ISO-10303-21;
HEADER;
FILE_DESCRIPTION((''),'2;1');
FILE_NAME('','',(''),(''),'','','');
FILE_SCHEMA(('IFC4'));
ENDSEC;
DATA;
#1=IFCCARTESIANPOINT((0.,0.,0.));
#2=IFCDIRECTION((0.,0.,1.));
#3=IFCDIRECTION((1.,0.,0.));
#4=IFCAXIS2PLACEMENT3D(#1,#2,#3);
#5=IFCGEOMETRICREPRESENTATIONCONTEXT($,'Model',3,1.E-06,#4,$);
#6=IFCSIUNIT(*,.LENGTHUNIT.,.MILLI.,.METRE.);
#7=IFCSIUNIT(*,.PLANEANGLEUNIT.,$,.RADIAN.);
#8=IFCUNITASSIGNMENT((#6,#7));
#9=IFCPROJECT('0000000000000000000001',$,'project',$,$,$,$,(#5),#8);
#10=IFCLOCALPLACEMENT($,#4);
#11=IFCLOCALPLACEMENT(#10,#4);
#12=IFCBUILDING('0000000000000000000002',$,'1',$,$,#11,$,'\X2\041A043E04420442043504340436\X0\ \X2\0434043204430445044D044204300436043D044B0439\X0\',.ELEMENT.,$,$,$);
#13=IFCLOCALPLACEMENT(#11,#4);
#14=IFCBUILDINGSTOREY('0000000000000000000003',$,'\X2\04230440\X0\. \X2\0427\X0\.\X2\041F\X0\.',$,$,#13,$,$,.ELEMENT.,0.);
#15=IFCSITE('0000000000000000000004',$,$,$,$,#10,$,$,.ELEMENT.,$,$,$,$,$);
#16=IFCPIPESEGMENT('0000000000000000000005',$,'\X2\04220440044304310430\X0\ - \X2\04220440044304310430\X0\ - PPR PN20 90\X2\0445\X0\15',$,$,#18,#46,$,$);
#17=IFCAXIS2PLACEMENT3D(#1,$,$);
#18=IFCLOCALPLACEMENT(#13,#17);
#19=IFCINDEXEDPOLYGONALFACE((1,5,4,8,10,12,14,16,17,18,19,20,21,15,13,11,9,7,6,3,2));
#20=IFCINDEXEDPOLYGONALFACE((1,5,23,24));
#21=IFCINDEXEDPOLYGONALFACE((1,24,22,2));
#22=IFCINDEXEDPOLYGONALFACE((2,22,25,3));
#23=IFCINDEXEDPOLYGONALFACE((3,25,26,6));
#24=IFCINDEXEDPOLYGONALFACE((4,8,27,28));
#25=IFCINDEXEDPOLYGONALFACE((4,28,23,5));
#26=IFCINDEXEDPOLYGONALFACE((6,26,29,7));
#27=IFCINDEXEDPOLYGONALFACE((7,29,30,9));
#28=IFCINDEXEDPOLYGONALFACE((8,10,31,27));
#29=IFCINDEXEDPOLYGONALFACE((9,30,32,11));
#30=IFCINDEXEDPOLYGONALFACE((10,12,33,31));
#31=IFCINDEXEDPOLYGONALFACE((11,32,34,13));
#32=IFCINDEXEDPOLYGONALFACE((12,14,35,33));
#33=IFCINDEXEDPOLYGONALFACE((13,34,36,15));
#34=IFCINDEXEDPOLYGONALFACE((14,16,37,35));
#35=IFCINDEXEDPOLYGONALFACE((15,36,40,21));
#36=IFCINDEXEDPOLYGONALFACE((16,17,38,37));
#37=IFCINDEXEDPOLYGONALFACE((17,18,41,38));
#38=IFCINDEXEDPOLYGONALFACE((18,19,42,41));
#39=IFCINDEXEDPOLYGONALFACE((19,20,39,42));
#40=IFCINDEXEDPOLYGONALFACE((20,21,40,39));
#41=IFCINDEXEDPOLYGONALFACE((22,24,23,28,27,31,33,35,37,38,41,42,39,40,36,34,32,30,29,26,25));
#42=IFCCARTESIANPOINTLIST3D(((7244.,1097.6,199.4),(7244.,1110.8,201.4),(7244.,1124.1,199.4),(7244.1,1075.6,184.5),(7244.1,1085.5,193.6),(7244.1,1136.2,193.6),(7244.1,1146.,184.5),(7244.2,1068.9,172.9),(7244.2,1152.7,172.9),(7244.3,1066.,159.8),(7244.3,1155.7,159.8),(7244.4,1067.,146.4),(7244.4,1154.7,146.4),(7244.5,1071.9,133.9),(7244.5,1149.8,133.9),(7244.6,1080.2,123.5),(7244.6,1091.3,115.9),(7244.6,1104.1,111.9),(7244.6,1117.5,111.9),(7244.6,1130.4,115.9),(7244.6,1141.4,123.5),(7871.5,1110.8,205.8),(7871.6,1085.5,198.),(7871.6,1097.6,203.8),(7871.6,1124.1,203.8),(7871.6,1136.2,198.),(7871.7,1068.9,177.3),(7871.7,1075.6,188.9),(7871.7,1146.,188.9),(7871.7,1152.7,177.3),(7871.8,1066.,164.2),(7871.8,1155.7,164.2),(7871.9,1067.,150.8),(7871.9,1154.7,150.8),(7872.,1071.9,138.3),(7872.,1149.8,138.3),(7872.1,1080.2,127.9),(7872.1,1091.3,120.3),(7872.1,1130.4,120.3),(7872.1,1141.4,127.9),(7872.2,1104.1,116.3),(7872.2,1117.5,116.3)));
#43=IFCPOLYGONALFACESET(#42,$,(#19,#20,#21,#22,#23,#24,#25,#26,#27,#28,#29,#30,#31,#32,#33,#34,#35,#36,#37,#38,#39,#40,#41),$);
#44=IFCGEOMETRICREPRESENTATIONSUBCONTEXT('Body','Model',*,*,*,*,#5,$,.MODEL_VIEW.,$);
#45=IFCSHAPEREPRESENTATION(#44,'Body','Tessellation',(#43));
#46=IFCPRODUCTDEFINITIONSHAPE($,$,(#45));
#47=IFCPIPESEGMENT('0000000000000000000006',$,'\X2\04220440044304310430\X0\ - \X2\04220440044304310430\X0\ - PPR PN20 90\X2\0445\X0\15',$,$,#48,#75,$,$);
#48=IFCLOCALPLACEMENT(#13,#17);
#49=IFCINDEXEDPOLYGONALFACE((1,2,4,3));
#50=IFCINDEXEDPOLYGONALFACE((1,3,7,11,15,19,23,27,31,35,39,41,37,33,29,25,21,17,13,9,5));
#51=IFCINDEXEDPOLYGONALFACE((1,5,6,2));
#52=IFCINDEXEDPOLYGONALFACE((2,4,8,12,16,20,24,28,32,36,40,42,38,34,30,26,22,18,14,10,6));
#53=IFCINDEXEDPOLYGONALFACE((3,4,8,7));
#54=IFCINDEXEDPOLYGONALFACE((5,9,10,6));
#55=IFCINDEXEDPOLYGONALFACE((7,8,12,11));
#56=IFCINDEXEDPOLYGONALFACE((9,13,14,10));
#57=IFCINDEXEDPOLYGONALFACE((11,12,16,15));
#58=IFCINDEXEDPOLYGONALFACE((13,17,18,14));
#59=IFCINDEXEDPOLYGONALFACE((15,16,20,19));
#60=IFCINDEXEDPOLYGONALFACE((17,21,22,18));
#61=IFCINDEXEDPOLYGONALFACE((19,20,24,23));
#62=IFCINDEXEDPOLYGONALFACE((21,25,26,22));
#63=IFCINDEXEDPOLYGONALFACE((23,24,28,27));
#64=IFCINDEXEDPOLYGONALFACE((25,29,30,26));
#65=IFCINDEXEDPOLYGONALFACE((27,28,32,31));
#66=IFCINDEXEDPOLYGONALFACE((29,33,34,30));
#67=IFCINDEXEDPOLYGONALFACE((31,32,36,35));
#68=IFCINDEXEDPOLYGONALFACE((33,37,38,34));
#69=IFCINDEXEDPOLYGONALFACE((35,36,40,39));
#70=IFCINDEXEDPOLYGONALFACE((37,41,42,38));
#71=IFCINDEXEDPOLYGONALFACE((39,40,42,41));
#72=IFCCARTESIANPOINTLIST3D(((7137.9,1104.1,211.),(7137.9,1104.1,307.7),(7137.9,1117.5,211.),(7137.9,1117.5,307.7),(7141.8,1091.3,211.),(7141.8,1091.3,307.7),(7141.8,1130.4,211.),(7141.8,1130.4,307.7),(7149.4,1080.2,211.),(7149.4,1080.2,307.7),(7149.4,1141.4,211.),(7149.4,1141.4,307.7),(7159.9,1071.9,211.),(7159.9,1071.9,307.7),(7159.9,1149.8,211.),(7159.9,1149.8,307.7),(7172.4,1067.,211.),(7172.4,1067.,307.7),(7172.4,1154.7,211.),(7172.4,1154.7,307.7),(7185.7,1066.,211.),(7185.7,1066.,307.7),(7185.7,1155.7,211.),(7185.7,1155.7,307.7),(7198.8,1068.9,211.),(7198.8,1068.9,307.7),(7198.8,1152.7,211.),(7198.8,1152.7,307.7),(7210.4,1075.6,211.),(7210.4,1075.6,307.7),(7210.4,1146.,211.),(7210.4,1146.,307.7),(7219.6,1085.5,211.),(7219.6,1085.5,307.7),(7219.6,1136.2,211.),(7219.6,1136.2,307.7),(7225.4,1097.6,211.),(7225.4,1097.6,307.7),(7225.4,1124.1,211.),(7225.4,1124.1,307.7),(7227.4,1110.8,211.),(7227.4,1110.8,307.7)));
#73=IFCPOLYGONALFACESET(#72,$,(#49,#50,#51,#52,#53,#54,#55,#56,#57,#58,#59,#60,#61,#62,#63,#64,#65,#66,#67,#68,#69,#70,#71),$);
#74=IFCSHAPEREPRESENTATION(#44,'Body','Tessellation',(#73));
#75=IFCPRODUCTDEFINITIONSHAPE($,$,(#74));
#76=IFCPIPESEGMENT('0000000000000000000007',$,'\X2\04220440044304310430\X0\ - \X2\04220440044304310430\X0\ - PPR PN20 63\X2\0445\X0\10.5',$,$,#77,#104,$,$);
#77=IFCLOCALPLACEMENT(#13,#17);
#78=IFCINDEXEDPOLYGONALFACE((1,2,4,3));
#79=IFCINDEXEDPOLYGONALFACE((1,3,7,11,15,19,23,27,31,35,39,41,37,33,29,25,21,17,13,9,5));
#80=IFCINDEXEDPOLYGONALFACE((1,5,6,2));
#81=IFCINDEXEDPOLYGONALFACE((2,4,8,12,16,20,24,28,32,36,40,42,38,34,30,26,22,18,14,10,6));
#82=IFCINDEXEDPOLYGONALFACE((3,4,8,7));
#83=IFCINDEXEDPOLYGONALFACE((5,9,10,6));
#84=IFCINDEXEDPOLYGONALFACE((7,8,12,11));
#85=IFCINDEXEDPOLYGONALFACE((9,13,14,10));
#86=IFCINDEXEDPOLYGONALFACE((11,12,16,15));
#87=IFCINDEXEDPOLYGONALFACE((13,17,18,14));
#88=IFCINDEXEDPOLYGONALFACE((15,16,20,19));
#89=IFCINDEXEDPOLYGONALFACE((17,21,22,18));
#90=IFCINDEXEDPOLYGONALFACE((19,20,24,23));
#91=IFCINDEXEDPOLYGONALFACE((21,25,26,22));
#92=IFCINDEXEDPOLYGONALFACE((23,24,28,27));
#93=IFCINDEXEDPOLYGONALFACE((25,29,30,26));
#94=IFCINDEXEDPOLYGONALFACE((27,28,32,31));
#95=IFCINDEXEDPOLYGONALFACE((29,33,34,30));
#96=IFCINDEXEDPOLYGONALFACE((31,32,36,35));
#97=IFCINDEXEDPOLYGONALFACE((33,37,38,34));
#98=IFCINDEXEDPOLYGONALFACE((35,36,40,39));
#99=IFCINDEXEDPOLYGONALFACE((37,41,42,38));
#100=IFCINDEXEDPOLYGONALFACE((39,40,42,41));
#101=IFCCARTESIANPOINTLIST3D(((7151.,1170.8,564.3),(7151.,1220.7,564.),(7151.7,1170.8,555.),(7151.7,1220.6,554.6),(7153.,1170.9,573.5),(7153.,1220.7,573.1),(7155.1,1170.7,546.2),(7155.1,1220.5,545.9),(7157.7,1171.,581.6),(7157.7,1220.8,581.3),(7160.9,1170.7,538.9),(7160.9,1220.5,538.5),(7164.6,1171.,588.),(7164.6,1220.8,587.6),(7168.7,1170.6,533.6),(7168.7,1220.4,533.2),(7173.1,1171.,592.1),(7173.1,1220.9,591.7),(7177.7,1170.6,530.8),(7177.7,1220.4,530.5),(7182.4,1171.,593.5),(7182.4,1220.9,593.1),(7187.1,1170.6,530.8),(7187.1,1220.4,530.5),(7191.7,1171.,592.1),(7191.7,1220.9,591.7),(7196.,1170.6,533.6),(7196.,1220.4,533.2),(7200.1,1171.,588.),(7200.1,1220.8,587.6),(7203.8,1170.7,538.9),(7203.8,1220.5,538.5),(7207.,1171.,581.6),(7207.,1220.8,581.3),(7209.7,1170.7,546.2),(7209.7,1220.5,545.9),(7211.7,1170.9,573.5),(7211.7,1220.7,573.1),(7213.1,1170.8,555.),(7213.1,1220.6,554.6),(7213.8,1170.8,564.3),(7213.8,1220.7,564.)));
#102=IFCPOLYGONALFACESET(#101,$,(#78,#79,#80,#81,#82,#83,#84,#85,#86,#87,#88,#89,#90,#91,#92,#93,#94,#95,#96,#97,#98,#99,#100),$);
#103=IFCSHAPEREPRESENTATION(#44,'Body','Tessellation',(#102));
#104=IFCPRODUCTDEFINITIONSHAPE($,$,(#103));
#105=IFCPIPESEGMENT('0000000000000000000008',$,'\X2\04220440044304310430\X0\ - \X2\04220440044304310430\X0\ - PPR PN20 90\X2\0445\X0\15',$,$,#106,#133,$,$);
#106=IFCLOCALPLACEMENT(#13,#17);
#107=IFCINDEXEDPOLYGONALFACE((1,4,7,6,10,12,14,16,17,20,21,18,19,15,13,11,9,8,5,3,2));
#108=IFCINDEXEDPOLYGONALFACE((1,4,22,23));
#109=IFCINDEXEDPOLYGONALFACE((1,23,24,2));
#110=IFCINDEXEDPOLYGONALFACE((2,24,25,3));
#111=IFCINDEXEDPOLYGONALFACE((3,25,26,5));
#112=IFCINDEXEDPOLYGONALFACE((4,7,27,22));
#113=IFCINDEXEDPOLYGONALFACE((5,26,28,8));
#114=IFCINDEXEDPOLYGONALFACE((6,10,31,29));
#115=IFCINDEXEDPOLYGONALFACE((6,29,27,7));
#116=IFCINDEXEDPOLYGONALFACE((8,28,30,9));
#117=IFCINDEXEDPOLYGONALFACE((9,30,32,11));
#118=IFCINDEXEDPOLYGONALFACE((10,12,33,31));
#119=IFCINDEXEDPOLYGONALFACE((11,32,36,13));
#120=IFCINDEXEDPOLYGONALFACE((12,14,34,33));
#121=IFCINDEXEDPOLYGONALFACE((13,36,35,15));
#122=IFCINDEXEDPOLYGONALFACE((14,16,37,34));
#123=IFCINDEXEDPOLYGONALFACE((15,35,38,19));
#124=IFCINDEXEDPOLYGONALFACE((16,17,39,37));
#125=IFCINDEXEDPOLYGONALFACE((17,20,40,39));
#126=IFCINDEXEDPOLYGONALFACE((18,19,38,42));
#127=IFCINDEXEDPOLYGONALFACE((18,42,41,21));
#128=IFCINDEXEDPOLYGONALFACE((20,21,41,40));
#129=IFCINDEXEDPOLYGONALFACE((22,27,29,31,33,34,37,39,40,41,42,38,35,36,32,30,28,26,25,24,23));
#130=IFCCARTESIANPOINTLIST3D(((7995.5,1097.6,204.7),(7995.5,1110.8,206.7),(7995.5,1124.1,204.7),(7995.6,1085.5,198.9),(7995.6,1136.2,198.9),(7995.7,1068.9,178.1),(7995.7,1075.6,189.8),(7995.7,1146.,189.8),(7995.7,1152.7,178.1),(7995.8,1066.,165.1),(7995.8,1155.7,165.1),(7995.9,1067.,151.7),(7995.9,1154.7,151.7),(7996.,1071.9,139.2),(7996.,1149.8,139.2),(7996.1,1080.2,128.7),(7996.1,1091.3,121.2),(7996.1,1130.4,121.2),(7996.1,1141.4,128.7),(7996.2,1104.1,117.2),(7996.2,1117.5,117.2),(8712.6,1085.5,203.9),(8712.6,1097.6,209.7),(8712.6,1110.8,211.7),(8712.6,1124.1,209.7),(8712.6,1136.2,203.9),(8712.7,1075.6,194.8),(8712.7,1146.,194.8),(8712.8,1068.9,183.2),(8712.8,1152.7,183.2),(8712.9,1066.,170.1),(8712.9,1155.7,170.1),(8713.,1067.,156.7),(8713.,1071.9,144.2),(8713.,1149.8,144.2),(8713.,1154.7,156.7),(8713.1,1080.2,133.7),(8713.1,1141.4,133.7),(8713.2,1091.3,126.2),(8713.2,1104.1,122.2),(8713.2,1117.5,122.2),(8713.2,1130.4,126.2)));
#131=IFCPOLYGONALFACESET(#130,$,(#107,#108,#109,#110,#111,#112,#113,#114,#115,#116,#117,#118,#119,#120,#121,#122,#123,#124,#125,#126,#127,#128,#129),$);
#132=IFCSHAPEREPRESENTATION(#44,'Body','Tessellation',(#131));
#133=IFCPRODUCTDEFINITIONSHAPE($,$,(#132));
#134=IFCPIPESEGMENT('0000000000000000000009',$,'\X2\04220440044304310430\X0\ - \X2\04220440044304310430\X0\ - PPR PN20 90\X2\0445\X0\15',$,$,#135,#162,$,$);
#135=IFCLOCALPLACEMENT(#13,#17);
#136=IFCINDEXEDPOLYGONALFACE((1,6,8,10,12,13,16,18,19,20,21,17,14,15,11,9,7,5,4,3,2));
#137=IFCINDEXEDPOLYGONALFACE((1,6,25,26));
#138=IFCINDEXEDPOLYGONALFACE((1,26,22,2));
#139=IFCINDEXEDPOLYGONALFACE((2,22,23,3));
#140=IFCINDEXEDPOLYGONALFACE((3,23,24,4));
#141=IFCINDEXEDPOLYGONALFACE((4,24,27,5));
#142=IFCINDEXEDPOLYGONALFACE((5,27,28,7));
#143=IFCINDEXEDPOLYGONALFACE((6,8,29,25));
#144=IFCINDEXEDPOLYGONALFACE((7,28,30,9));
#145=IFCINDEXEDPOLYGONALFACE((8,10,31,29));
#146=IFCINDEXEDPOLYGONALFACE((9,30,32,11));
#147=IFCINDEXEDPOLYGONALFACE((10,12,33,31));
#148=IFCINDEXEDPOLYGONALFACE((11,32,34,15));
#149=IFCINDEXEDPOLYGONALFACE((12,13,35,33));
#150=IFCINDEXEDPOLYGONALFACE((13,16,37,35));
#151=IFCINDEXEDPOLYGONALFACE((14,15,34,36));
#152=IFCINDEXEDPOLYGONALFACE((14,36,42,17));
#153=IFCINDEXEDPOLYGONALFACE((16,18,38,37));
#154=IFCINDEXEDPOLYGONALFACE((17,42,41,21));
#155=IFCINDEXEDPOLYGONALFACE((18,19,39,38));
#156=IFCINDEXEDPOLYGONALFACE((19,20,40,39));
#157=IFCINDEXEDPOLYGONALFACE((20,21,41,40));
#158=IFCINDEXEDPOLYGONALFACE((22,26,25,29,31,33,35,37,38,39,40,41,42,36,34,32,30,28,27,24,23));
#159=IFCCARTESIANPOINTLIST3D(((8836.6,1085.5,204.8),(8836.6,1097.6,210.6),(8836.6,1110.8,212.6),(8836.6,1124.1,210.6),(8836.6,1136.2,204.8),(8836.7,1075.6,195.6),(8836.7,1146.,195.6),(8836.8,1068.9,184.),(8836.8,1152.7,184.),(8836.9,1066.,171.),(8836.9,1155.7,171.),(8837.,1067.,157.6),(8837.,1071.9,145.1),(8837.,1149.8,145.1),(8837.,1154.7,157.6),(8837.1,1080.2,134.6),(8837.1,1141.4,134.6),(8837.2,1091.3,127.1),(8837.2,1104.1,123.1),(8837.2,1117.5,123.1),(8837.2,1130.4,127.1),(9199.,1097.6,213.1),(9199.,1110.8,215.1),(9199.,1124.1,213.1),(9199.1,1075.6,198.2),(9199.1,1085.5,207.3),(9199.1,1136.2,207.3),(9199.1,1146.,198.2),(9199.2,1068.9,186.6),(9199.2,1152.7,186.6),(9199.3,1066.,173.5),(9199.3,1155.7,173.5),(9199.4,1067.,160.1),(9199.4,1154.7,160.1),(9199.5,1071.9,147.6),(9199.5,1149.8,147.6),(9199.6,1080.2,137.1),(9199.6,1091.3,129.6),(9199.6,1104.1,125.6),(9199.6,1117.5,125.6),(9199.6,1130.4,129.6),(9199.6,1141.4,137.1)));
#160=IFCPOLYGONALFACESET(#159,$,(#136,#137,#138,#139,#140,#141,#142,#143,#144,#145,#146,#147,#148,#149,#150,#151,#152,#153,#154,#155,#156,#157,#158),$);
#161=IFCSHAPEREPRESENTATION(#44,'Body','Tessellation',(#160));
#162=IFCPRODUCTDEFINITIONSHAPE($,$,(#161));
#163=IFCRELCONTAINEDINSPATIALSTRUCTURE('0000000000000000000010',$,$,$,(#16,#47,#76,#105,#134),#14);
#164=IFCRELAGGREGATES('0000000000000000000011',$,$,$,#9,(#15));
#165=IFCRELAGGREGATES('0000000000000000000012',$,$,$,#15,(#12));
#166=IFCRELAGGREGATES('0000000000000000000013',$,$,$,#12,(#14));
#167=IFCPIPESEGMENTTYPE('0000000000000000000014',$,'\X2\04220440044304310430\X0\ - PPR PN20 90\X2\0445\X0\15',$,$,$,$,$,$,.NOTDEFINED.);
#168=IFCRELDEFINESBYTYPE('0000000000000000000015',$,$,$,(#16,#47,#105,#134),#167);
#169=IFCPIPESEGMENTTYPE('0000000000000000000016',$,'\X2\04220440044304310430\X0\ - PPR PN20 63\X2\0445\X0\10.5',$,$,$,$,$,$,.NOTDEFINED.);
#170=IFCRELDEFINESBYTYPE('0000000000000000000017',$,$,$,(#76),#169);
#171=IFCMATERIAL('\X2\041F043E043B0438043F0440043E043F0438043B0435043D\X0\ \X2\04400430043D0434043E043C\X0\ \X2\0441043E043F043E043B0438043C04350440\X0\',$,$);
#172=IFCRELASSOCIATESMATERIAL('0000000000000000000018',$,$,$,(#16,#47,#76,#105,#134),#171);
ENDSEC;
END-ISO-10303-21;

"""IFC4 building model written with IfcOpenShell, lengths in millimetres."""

from ifc_helpers import new_model, entity, si_unit, frame, origin_with_axes, place, context, subcontext, project, spatial, source, transform, mapped, material, type_object, element, save


model = new_model("IFC4")

# Units and contexts
model_context = context("Model", 3, precision=1e-06, world=origin_with_axes())
body_context = subcontext(model_context, "Body", "Model", "MODEL_VIEW")
ifc_project = project(units=[si_unit("LENGTHUNIT", "METRE", prefix="MILLI"), si_unit("PLANEANGLEUNIT", "RADIAN")], contexts=[model_context])

# Site, building, storey
site_placement = place(None, origin_with_axes())
site = spatial("IfcSite", under=ifc_project, at=site_placement, CompositionType="ELEMENT")
building_placement = place(site_placement, origin_with_axes())
building = spatial("IfcBuilding", under=site, at=building_placement, Name="1", LongName="Коттедж двухэтажный", CompositionType="ELEMENT")
storey_placement = place(building_placement, origin_with_axes())
storey = spatial("IfcBuildingStorey", under=building, at=storey_placement, Name="Ур. Ч.П.", CompositionType="ELEMENT", Elevation=0.0)

# Pipe segments
ifc_material = material(Name="Полипропилен рандом сополимер")
pipe_segment_type_1 = type_object("IfcPipeSegmentType", Name="Труба - PPR PN20 90х15", PredefinedType="NOTDEFINED")
pipe_segment_type_2 = type_object("IfcPipeSegmentType", Name="Труба - PPR PN20 63х10.5", PredefinedType="NOTDEFINED")
shared_shape_1 = source(origin_with_axes(), body_context, "Body", "AdvancedSweptSolid", [
    entity("IfcSweptDiskSolid", entity("IfcIndexedPolyCurve", entity("IfcCartesianPointList3D", [[0.0, 0.0, 0.0], [627.5, 0.0, 4.4]]), [entity("IfcLineIndex", [1, 2])]), 45.0),
])
pipe_segment_1_placement = place(storey_placement, frame((7244.3, 1110.8, 156.4), z_axis=(0.0, 0.0, 1.0), x_axis=(1.0, 0.0, 0.0)))
element("IfcPipeSegment", 1, at=pipe_segment_1_placement, inside=storey, type_object=pipe_segment_type_1, material=ifc_material, Name="Труба - Труба - PPR PN20 90х15", context=body_context, shape_type="MappedRepresentation", body=[
    mapped(shared_shape_1, transform((0.0, 0.0, 0.0), x_axis=(1.0, 0.0, 0.0), y_axis=(0.0, 1.0, 0.0), z_axis=(0.0, 0.0, 1.0), scale=1.0)),
])
shared_shape_2 = source(origin_with_axes(), body_context, "Body", "AdvancedSweptSolid", [
    entity("IfcSweptDiskSolid", entity("IfcIndexedPolyCurve", entity("IfcCartesianPointList3D", [[0.0, 0.0, 0.0], [0.0, 0.0, -96.7]]), [entity("IfcLineIndex", [1, 2])]), 45.0),
])
pipe_segment_2_placement = place(storey_placement, frame((7182.4, 1110.8, 307.7), z_axis=(0.0, 0.0, 1.0), x_axis=(-1.0, 0.0, 0.0)))
element("IfcPipeSegment", 2, at=pipe_segment_2_placement, inside=storey, type_object=pipe_segment_type_1, material=ifc_material, Name="Труба - Труба - PPR PN20 90х15", context=body_context, shape_type="MappedRepresentation", body=[
    mapped(shared_shape_2, transform((0.0, 0.0, 0.0), x_axis=(1.0, 0.0, 0.0), y_axis=(0.0, 1.0, 0.0), z_axis=(0.0, 0.0, 1.0), scale=1.0)),
])
shared_shape_3 = source(origin_with_axes(), body_context, "Body", "AdvancedSweptSolid", [
    entity("IfcSweptDiskSolid", entity("IfcIndexedPolyCurve", entity("IfcCartesianPointList3D", [[0.0, 0.0, 0.0], [49.8, 0.0, 0.3]]), [entity("IfcLineIndex", [1, 2])]), 31.5),
])
pipe_segment_3_placement = place(storey_placement, frame((7182.4, 1220.6, 561.6), z_axis=(0.0, 0.0, 1.0), x_axis=(0.0, -1.0, 0.0)))
element("IfcPipeSegment", 3, at=pipe_segment_3_placement, inside=storey, type_object=pipe_segment_type_2, material=ifc_material, Name="Труба - Труба - PPR PN20 63х10.5", context=body_context, shape_type="MappedRepresentation", body=[
    mapped(shared_shape_3, transform((0.0, 0.0, 0.0), x_axis=(1.0, 0.0, 0.0), y_axis=(0.0, 1.0, 0.0), z_axis=(0.0, 0.0, 1.0), scale=1.0)),
])
shared_shape_4 = source(origin_with_axes(), body_context, "Body", "AdvancedSweptSolid", [
    entity("IfcSweptDiskSolid", entity("IfcIndexedPolyCurve", entity("IfcCartesianPointList3D", [[0.0, 0.0, 0.0], [717.0, 0.0, 5.0]]), [entity("IfcLineIndex", [1, 2])]), 45.0),
])
pipe_segment_4_placement = place(storey_placement, frame((7995.9, 1110.8, 161.7), z_axis=(0.0, 0.0, 1.0), x_axis=(1.0, 0.0, 0.0)))
element("IfcPipeSegment", 4, at=pipe_segment_4_placement, inside=storey, type_object=pipe_segment_type_1, material=ifc_material, Name="Труба - Труба - PPR PN20 90х15", context=body_context, shape_type="MappedRepresentation", body=[
    mapped(shared_shape_4, transform((0.0, 0.0, 0.0), x_axis=(1.0, 0.0, 0.0), y_axis=(0.0, 1.0, 0.0), z_axis=(0.0, 0.0, 1.0), scale=1.0)),
])
shared_shape_5 = source(origin_with_axes(), body_context, "Body", "AdvancedSweptSolid", [
    entity("IfcSweptDiskSolid", entity("IfcIndexedPolyCurve", entity("IfcCartesianPointList3D", [[0.0, 0.0, 0.0], [362.5, 0.0, 2.5]]), [entity("IfcLineIndex", [1, 2])]), 45.0),
])
pipe_segment_5_placement = place(storey_placement, frame((8836.9, 1110.8, 167.6), z_axis=(0.0, 0.0, 1.0), x_axis=(1.0, 0.0, 0.0)))
element("IfcPipeSegment", 5, at=pipe_segment_5_placement, inside=storey, type_object=pipe_segment_type_1, material=ifc_material, Name="Труба - Труба - PPR PN20 90х15", context=body_context, shape_type="MappedRepresentation", body=[
    mapped(shared_shape_5, transform((0.0, 0.0, 0.0), x_axis=(1.0, 0.0, 0.0), y_axis=(0.0, 1.0, 0.0), z_axis=(0.0, 0.0, 1.0), scale=1.0)),
])

save(model, "model.ifc")
